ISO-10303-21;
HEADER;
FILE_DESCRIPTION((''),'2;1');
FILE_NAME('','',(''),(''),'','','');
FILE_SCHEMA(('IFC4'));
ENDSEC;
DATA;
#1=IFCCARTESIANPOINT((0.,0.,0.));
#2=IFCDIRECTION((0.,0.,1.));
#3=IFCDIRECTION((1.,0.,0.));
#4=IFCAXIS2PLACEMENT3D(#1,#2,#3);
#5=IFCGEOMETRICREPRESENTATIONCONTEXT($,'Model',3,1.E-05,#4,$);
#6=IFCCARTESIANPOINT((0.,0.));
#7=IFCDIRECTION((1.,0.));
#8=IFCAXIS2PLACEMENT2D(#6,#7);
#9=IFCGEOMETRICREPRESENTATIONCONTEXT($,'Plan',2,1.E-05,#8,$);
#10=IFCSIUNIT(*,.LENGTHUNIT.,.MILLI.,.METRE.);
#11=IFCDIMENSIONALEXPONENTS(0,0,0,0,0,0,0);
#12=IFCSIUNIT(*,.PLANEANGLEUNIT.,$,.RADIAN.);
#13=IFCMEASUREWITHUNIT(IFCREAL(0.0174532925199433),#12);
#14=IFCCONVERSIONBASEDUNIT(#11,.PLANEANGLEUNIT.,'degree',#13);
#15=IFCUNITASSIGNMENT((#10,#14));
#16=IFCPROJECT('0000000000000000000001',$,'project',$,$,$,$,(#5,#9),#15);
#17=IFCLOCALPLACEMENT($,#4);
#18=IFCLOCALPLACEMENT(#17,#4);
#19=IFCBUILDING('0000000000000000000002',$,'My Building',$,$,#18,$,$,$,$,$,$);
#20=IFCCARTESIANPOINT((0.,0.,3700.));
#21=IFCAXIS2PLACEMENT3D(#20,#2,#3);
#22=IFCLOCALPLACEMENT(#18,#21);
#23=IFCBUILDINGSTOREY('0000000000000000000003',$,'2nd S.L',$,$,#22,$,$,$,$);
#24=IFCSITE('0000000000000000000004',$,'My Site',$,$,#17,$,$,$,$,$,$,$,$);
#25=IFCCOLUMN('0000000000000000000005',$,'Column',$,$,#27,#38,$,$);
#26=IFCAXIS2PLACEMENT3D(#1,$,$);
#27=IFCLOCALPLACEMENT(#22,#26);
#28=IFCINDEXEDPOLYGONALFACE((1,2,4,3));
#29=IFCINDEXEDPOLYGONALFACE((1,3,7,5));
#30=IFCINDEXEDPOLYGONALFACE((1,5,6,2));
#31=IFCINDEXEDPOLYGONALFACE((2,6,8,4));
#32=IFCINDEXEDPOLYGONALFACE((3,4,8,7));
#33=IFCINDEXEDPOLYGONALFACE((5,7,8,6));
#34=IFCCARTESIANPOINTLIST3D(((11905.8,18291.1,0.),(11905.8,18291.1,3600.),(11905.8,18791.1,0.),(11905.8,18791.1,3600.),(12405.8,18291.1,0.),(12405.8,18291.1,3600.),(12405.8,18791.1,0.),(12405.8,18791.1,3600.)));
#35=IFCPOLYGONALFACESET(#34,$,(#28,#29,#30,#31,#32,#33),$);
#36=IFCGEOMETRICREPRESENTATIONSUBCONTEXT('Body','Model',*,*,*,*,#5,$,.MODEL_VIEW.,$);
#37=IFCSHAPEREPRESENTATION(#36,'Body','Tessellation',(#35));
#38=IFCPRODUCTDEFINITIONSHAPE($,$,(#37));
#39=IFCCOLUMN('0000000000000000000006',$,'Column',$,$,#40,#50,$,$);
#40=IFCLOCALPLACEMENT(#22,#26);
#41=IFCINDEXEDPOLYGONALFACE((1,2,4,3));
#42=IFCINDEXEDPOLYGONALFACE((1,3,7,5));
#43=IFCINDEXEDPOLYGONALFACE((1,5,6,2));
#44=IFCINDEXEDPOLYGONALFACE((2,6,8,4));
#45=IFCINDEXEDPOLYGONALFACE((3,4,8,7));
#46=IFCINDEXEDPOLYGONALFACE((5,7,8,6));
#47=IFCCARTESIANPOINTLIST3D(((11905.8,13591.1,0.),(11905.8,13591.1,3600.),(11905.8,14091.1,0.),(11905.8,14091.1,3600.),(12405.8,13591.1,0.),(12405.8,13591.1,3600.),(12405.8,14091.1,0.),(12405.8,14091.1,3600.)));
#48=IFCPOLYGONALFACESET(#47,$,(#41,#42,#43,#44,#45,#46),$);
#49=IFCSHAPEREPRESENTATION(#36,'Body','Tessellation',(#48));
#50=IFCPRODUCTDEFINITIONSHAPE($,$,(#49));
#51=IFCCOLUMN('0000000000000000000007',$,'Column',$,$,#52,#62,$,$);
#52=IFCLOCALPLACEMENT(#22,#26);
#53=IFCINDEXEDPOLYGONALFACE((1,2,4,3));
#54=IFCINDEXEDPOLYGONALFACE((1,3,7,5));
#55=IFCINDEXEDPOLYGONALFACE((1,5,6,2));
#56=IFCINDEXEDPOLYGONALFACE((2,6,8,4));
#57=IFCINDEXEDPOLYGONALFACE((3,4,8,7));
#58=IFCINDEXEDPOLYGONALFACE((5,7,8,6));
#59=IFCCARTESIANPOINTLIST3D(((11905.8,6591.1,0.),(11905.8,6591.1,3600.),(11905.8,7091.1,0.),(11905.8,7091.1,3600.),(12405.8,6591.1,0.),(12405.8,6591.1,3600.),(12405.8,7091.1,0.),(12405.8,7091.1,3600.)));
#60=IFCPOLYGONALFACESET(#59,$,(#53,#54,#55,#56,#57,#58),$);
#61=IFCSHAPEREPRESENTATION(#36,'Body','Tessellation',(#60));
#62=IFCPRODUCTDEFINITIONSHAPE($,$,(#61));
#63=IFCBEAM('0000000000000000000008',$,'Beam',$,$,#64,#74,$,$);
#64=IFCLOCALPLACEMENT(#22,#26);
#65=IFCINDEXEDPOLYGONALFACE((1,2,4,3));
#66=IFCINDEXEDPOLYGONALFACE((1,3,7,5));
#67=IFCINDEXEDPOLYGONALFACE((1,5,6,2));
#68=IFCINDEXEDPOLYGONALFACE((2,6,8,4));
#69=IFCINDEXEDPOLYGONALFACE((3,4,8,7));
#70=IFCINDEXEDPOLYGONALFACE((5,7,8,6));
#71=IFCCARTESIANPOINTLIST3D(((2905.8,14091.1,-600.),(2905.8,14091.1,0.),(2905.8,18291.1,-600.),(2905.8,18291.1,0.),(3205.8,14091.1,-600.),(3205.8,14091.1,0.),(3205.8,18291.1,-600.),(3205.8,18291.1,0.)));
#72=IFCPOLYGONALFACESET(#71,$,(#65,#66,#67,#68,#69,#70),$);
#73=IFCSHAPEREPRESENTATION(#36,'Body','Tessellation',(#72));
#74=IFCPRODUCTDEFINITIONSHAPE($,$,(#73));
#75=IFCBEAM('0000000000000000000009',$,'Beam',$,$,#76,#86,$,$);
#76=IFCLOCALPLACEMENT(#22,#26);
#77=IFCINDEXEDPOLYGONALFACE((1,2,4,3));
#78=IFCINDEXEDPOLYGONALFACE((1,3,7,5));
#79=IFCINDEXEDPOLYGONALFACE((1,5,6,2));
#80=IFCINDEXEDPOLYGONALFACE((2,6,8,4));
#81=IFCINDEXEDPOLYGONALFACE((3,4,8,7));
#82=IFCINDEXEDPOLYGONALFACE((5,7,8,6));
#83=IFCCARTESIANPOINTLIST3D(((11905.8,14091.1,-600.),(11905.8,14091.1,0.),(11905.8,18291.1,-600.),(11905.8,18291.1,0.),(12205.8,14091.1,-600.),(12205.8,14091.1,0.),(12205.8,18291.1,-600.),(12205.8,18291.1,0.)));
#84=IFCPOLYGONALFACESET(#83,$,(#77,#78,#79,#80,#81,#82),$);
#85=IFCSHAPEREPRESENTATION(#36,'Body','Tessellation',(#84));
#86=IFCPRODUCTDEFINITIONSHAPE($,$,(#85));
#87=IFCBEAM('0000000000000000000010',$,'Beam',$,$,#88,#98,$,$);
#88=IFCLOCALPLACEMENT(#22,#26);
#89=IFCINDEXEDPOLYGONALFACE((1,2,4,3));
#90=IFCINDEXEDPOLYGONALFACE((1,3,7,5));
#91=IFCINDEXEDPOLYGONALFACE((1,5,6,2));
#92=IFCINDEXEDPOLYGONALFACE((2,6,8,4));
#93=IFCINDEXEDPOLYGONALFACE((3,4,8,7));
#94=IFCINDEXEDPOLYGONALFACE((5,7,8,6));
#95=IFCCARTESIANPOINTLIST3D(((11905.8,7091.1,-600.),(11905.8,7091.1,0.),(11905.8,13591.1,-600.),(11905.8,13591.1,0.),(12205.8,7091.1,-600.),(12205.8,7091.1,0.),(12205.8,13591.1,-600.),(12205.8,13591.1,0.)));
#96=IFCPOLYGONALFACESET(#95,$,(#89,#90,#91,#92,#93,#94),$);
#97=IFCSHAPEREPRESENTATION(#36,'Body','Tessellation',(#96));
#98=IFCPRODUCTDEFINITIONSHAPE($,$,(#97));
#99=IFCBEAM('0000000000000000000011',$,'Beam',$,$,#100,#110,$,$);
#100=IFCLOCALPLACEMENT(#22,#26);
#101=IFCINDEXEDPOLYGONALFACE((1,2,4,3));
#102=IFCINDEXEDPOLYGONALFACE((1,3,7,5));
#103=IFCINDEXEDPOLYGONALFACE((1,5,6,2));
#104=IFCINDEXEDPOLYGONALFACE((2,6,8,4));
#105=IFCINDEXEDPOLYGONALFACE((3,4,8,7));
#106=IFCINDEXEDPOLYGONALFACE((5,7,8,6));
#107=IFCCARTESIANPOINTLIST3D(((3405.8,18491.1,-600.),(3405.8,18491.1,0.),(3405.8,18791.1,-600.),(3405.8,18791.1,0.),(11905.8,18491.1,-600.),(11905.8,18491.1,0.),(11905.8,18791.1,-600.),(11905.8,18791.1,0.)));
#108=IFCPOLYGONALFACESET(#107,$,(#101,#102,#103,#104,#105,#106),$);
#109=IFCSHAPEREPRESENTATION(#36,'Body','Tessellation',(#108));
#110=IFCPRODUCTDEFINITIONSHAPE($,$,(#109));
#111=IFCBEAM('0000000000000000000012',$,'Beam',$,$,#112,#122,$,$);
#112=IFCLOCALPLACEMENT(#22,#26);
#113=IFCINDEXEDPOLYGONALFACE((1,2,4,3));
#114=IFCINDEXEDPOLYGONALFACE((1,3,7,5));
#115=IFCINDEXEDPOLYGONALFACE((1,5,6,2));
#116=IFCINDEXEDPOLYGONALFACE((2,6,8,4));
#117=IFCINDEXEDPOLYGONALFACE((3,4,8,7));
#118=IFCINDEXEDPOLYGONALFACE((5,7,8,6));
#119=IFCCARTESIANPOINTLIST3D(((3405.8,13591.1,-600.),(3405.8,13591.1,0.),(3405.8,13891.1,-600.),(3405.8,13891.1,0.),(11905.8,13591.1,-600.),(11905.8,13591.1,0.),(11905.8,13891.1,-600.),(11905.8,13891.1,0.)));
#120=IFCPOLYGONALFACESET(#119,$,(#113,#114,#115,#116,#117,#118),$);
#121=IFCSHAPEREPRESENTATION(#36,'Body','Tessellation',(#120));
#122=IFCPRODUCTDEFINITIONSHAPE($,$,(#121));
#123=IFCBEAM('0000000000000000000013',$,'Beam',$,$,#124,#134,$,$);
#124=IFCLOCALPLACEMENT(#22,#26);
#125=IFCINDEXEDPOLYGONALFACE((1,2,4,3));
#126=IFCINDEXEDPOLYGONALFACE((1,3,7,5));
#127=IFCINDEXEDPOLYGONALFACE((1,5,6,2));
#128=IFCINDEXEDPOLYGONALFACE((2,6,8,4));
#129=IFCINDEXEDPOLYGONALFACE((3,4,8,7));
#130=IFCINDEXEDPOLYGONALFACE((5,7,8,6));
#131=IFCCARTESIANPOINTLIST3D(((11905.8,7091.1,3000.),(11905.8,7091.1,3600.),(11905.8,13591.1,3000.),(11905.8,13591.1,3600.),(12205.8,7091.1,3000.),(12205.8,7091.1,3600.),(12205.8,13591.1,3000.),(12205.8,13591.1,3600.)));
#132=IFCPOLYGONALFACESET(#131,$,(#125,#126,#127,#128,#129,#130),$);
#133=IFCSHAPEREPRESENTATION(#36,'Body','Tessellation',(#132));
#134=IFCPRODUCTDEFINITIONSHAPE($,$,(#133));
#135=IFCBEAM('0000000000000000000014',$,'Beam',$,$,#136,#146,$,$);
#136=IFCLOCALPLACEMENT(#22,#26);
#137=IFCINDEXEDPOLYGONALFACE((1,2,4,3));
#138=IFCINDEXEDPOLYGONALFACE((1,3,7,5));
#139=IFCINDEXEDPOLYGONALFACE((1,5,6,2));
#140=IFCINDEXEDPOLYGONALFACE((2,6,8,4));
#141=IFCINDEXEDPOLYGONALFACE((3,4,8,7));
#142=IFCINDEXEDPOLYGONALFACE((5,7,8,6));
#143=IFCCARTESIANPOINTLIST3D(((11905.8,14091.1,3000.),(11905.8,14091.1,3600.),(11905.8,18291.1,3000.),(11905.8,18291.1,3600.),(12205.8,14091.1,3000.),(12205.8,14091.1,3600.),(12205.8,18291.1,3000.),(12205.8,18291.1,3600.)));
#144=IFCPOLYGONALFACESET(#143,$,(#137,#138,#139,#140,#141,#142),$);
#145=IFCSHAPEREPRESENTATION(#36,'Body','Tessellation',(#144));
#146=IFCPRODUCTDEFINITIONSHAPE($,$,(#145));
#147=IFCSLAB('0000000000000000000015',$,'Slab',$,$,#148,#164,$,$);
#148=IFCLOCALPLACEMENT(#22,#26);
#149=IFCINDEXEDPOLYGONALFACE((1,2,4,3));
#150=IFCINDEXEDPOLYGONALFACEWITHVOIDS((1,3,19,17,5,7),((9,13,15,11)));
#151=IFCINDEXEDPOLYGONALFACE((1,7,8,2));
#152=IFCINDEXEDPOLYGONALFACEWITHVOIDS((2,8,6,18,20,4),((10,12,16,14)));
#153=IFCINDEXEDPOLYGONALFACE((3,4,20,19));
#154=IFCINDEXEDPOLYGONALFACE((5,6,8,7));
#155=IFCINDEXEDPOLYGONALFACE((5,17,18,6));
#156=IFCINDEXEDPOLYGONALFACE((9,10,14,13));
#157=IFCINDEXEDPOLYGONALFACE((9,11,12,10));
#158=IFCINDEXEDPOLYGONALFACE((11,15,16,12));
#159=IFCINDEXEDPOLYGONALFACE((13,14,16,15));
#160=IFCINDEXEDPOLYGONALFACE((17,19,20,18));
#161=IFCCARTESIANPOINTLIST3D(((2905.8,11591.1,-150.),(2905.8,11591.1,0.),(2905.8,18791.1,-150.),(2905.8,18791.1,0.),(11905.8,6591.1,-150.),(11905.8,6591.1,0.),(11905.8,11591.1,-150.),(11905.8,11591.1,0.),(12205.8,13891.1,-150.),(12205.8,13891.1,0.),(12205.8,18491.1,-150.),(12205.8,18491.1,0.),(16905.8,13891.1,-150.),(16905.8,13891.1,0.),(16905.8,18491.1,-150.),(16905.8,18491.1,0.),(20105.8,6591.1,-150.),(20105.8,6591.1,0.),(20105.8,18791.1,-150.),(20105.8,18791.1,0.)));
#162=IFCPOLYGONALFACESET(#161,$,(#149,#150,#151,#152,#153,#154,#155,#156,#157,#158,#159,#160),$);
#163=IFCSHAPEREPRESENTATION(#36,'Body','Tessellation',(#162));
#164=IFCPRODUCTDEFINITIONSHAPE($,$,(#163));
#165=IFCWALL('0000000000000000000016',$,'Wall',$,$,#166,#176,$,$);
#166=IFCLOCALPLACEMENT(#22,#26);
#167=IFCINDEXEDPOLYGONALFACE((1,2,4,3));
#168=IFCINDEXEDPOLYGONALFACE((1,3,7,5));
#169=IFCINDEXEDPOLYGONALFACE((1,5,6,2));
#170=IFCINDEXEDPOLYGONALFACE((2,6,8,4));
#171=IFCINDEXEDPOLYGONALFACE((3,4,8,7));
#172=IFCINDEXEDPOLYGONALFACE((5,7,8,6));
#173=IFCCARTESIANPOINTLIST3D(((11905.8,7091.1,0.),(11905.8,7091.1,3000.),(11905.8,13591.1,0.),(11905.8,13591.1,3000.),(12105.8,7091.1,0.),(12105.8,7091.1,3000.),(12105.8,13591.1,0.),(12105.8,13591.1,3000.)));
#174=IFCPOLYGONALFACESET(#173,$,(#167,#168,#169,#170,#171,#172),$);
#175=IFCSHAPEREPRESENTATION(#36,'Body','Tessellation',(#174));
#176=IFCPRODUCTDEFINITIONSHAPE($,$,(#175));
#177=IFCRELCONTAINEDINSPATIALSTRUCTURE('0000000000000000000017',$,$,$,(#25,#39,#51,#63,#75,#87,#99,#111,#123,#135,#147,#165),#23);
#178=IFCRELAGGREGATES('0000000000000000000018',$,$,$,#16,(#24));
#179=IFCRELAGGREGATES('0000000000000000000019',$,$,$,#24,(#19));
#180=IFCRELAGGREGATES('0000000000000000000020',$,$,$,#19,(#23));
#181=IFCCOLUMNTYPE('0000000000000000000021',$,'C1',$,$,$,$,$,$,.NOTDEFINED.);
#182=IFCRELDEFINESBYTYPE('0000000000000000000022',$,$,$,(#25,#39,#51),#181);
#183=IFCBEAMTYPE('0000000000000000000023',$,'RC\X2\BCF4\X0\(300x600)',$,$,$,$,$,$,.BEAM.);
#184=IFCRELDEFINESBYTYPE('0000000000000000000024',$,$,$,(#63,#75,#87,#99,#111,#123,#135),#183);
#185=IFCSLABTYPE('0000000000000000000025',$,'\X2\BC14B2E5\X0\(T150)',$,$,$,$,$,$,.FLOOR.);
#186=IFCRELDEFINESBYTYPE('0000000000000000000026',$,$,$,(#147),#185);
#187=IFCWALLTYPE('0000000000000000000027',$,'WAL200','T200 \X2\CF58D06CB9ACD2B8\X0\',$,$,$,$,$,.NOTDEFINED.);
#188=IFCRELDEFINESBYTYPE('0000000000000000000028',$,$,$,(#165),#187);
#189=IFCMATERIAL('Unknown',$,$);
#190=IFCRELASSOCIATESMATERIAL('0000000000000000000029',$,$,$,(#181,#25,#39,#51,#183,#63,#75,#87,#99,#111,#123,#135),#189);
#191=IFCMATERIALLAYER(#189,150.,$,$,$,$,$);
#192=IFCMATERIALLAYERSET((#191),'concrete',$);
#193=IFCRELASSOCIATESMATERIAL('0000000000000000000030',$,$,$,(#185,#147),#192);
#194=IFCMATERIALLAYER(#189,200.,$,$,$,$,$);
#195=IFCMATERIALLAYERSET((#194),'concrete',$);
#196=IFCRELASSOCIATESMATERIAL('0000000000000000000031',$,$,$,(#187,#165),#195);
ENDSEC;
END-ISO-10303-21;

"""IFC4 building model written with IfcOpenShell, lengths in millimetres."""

from ifc_helpers import new_model, entity, si_unit, converted_unit, frame, origin_with_axes, origin_2d_with_axis, place, context, subcontext, project, spatial, indexed_curve, rectangle, outline, extrude, material, layer, layer_set, layer_usage, material_profile, profile_set, profile_usage, type_object, element, save


model = new_model("IFC4")

# Units and contexts
model_context = context("Model", 3, precision=1e-05, world=origin_with_axes())
plan_context = context("Plan", 2, precision=1e-05, world=origin_2d_with_axis())
body_context = subcontext(model_context, "Body", "Model", "MODEL_VIEW")
ifc_project = project(units=[si_unit("LENGTHUNIT", "METRE", prefix="MILLI"), converted_unit("PLANEANGLEUNIT", "degree", entity("IfcReal", 0.0174532925199433), si_unit("PLANEANGLEUNIT", "RADIAN"), dimensions=[0, 0, 0, 0, 0, 0, 0])], contexts=[model_context, plan_context])

# Site, building, storey
site_placement = place(None, origin_with_axes())
site = spatial("IfcSite", under=ifc_project, at=site_placement, Name="My Site")
building_placement = place(site_placement, origin_with_axes())
building = spatial("IfcBuilding", under=site, at=building_placement, Name="My Building")
storey_placement = place(building_placement, frame((0.0, 0.0, 3700.0), z_axis=(0.0, 0.0, 1.0), x_axis=(1.0, 0.0, 0.0)))
storey = spatial("IfcBuildingStorey", under=building, at=storey_placement, Name="2nd S.L")

# Columns
ifc_material_1 = material(Name="Unknown")
ifc_material_profile_1 = material_profile(ifc_material_1, rectangle(XDim=500.0, YDim=500.0, kind="CURVE"))
ifc_profile_set_1 = profile_set([ifc_material_profile_1], Name="concrete")
ifc_profile_usage_1 = profile_usage(ifc_profile_set_1, cardinal=5)
column_type = type_object("IfcColumnType", Name="C1", PredefinedType="NOTDEFINED", material=ifc_profile_set_1)
column_1_placement = place(storey_placement, frame((12155.8, 18541.1, 0.0), z_axis=(0.0, 0.0, 1.0), x_axis=(1.0, 0.0, 0.0)))
element("IfcColumn", 1, at=column_1_placement, inside=storey, type_object=column_type, material=ifc_profile_usage_1, Name="Column", context=body_context, shape_type="SweptSolid", body=[
    extrude(rectangle(XDim=500.0, YDim=500.0, kind="CURVE"), origin_with_axes(), (0.0, 0.0, 1.0), 3600.0),
])
ifc_profile_usage_2 = profile_usage(ifc_profile_set_1, cardinal=5)
column_2_placement = place(storey_placement, frame((12155.8, 13841.1, 0.0), z_axis=(0.0, 0.0, 1.0), x_axis=(1.0, 0.0, 0.0)))
element("IfcColumn", 2, at=column_2_placement, inside=storey, type_object=column_type, material=ifc_profile_usage_2, Name="Column", context=body_context, shape_type="SweptSolid", body=[
    extrude(rectangle(XDim=500.0, YDim=500.0, kind="CURVE"), origin_with_axes(), (0.0, 0.0, 1.0), 3600.0),
])
ifc_profile_usage_3 = profile_usage(ifc_profile_set_1, cardinal=5)
column_3_placement = place(storey_placement, frame((12155.8, 6841.1, 0.0), z_axis=(0.0, 0.0, 1.0), x_axis=(1.0, 0.0, 0.0)))
element("IfcColumn", 3, at=column_3_placement, inside=storey, type_object=column_type, material=ifc_profile_usage_3, Name="Column", context=body_context, shape_type="SweptSolid", body=[
    extrude(rectangle(XDim=500.0, YDim=500.0, kind="CURVE"), origin_with_axes(), (0.0, 0.0, 1.0), 3600.0),
])

# Beams
ifc_material_profile_2 = material_profile(ifc_material_1, outline(indexed_curve([(-150.0, 300.0), (150.0, 300.0), (150.0, -300.0), (-150.0, -300.0), (-150.0, 300.0)])))
ifc_profile_set_2 = profile_set([ifc_material_profile_2], Name="concrete")
ifc_profile_usage_4 = profile_usage(ifc_profile_set_2, cardinal=5)
beam_type = type_object("IfcBeamType", Name="RC보(300x600)", PredefinedType="BEAM", material=ifc_profile_set_2)
beam_1_placement = place(storey_placement, frame((3055.8, 18291.1, -300.0), z_axis=(0.0, -1.0, 0.0), x_axis=(1.0, 0.0, 0.0)))
element("IfcBeam", 4, at=beam_1_placement, inside=storey, type_object=beam_type, material=ifc_profile_usage_4, Name="Beam", context=body_context, shape_type="SweptSolid", body=[
    extrude(outline(indexed_curve([(-150.0, 300.0), (150.0, 300.0), (150.0, -300.0), (-150.0, -300.0), (-150.0, 300.0)])), origin_with_axes(), (0.0, 0.0, 1.0), 4200.0),
])
ifc_profile_usage_5 = profile_usage(ifc_profile_set_2, cardinal=5)
beam_2_placement = place(storey_placement, frame((12055.8, 18291.1, -300.0), z_axis=(0.0, -1.0, 0.0), x_axis=(1.0, 0.0, 0.0)))
element("IfcBeam", 5, at=beam_2_placement, inside=storey, type_object=beam_type, material=ifc_profile_usage_5, Name="Beam", context=body_context, shape_type="SweptSolid", body=[
    extrude(outline(indexed_curve([(-150.0, 300.0), (150.0, 300.0), (150.0, -300.0), (-150.0, -300.0), (-150.0, 300.0)])), origin_with_axes(), (0.0, 0.0, 1.0), 4200.0),
])
ifc_profile_usage_6 = profile_usage(ifc_profile_set_2, cardinal=5)
beam_3_placement = place(storey_placement, frame((12055.8, 13591.1, -300.0), z_axis=(0.0, -1.0, 0.0), x_axis=(1.0, 0.0, 0.0)))
element("IfcBeam", 6, at=beam_3_placement, inside=storey, type_object=beam_type, material=ifc_profile_usage_6, Name="Beam", context=body_context, shape_type="SweptSolid", body=[
    extrude(outline(indexed_curve([(-150.0, 300.0), (150.0, 300.0), (150.0, -300.0), (-150.0, -300.0), (-150.0, 300.0)])), origin_with_axes(), (0.0, 0.0, 1.0), 6500.0),
])
ifc_profile_usage_7 = profile_usage(ifc_profile_set_2, cardinal=5)
beam_4_placement = place(storey_placement, frame((11905.8, 18641.1, -300.0), z_axis=(-1.0, 0.0, 0.0), x_axis=(0.0, -1.0, 0.0)))
element("IfcBeam", 7, at=beam_4_placement, inside=storey, type_object=beam_type, material=ifc_profile_usage_7, Name="Beam", context=body_context, shape_type="SweptSolid", body=[
    extrude(outline(indexed_curve([(-150.0, 300.0), (150.0, 300.0), (150.0, -300.0), (-150.0, -300.0), (-150.0, 300.0)])), origin_with_axes(), (0.0, 0.0, 1.0), 8500.0),
])
ifc_profile_usage_8 = profile_usage(ifc_profile_set_2, cardinal=5)
beam_5_placement = place(storey_placement, frame((11905.8, 13741.1, -300.0), z_axis=(-1.0, 0.0, 0.0), x_axis=(0.0, -1.0, 0.0)))
element("IfcBeam", 8, at=beam_5_placement, inside=storey, type_object=beam_type, material=ifc_profile_usage_8, Name="Beam", context=body_context, shape_type="SweptSolid", body=[
    extrude(outline(indexed_curve([(-150.0, 300.0), (150.0, 300.0), (150.0, -300.0), (-150.0, -300.0), (-150.0, 300.0)])), origin_with_axes(), (0.0, 0.0, 1.0), 8500.0),
])
ifc_profile_usage_9 = profile_usage(ifc_profile_set_2, cardinal=5)
beam_6_placement = place(storey_placement, frame((12055.8, 13591.1, 3300.0), z_axis=(0.0, -1.0, 0.0), x_axis=(1.0, 0.0, 0.0)))
element("IfcBeam", 9, at=beam_6_placement, inside=storey, type_object=beam_type, material=ifc_profile_usage_9, Name="Beam", context=body_context, shape_type="SweptSolid", body=[
    extrude(outline(indexed_curve([(-150.0, 300.0), (150.0, 300.0), (150.0, -300.0), (-150.0, -300.0), (-150.0, 300.0)])), origin_with_axes(), (0.0, 0.0, 1.0), 6500.0),
])
ifc_profile_usage_10 = profile_usage(ifc_profile_set_2, cardinal=5)
beam_7_placement = place(storey_placement, frame((12055.8, 18291.1, 3300.0), z_axis=(0.0, -1.0, 0.0), x_axis=(1.0, 0.0, 0.0)))
element("IfcBeam", 10, at=beam_7_placement, inside=storey, type_object=beam_type, material=ifc_profile_usage_10, Name="Beam", context=body_context, shape_type="SweptSolid", body=[
    extrude(outline(indexed_curve([(-150.0, 300.0), (150.0, 300.0), (150.0, -300.0), (-150.0, -300.0), (-150.0, 300.0)])), origin_with_axes(), (0.0, 0.0, 1.0), 4200.0),
])

# Slab
ifc_layer_1 = layer(ifc_material_1, 150.0)
ifc_layer_set_1 = layer_set([ifc_layer_1], Name="concrete")
ifc_layer_usage_1 = layer_usage(ifc_layer_set_1, "AXIS3", "POSITIVE", 0.0)
slab_type = type_object("IfcSlabType", Name="바닥(T150)", PredefinedType="FLOOR", material=ifc_layer_set_1)
slab_1_placement = place(storey_placement, frame((2905.8, 18791.1, -150.0), z_axis=(0.0, 0.0, 1.0), x_axis=(1.0, 0.0, 0.0)))
element("IfcSlab", 11, at=slab_1_placement, inside=storey, type_object=slab_type, material=ifc_layer_usage_1, Name="Slab", context=body_context, shape_type="SolidModel", body=[
    extrude(outline(indexed_curve([(9000.0, -7200.0), (9000.0, -12200.0), (17200.0, -12200.0), (17200.0, 0.0), (0.0, 0.0), (0.0, -7200.0), (9000.0, -7200.0)]), holes=[indexed_curve([(9300.0, -4900.0), (14000.0, -4900.0), (14000.0, -300.0), (9300.0, -300.0), (9300.0, -4900.0)])]), origin_with_axes(), (0.0, 0.0, 1.0), 150.0),
])

# Wall
ifc_layer_2 = layer(ifc_material_1, 200.0)
ifc_layer_set_2 = layer_set([ifc_layer_2], Name="concrete")
ifc_layer_usage_2 = layer_usage(ifc_layer_set_2, "AXIS2", "POSITIVE", 0.0)
wall_type = type_object("IfcWallType", Name="WAL200", Description="T200 콘크리트", PredefinedType="NOTDEFINED", material=ifc_layer_set_2)
wall_1_placement = place(storey_placement, frame((12105.8, 7091.1, 0.0), z_axis=(0.0, 0.0, 1.0), x_axis=(0.0, 1.0, 0.0)))
element("IfcWall", 12, at=wall_1_placement, inside=storey, type_object=wall_type, material=ifc_layer_usage_2, Name="Wall", context=body_context, shape_type="SweptSolid", body=[
    extrude(outline(indexed_curve([(0.0, 0.0), (0.0, 200.0), (6500.0, 200.0), (6500.0, 0.0), (0.0, 0.0)], self_intersect=False)), origin_with_axes(), (0.0, 0.0, 1.0), 3000.0),
])

save(model, "model.ifc")
